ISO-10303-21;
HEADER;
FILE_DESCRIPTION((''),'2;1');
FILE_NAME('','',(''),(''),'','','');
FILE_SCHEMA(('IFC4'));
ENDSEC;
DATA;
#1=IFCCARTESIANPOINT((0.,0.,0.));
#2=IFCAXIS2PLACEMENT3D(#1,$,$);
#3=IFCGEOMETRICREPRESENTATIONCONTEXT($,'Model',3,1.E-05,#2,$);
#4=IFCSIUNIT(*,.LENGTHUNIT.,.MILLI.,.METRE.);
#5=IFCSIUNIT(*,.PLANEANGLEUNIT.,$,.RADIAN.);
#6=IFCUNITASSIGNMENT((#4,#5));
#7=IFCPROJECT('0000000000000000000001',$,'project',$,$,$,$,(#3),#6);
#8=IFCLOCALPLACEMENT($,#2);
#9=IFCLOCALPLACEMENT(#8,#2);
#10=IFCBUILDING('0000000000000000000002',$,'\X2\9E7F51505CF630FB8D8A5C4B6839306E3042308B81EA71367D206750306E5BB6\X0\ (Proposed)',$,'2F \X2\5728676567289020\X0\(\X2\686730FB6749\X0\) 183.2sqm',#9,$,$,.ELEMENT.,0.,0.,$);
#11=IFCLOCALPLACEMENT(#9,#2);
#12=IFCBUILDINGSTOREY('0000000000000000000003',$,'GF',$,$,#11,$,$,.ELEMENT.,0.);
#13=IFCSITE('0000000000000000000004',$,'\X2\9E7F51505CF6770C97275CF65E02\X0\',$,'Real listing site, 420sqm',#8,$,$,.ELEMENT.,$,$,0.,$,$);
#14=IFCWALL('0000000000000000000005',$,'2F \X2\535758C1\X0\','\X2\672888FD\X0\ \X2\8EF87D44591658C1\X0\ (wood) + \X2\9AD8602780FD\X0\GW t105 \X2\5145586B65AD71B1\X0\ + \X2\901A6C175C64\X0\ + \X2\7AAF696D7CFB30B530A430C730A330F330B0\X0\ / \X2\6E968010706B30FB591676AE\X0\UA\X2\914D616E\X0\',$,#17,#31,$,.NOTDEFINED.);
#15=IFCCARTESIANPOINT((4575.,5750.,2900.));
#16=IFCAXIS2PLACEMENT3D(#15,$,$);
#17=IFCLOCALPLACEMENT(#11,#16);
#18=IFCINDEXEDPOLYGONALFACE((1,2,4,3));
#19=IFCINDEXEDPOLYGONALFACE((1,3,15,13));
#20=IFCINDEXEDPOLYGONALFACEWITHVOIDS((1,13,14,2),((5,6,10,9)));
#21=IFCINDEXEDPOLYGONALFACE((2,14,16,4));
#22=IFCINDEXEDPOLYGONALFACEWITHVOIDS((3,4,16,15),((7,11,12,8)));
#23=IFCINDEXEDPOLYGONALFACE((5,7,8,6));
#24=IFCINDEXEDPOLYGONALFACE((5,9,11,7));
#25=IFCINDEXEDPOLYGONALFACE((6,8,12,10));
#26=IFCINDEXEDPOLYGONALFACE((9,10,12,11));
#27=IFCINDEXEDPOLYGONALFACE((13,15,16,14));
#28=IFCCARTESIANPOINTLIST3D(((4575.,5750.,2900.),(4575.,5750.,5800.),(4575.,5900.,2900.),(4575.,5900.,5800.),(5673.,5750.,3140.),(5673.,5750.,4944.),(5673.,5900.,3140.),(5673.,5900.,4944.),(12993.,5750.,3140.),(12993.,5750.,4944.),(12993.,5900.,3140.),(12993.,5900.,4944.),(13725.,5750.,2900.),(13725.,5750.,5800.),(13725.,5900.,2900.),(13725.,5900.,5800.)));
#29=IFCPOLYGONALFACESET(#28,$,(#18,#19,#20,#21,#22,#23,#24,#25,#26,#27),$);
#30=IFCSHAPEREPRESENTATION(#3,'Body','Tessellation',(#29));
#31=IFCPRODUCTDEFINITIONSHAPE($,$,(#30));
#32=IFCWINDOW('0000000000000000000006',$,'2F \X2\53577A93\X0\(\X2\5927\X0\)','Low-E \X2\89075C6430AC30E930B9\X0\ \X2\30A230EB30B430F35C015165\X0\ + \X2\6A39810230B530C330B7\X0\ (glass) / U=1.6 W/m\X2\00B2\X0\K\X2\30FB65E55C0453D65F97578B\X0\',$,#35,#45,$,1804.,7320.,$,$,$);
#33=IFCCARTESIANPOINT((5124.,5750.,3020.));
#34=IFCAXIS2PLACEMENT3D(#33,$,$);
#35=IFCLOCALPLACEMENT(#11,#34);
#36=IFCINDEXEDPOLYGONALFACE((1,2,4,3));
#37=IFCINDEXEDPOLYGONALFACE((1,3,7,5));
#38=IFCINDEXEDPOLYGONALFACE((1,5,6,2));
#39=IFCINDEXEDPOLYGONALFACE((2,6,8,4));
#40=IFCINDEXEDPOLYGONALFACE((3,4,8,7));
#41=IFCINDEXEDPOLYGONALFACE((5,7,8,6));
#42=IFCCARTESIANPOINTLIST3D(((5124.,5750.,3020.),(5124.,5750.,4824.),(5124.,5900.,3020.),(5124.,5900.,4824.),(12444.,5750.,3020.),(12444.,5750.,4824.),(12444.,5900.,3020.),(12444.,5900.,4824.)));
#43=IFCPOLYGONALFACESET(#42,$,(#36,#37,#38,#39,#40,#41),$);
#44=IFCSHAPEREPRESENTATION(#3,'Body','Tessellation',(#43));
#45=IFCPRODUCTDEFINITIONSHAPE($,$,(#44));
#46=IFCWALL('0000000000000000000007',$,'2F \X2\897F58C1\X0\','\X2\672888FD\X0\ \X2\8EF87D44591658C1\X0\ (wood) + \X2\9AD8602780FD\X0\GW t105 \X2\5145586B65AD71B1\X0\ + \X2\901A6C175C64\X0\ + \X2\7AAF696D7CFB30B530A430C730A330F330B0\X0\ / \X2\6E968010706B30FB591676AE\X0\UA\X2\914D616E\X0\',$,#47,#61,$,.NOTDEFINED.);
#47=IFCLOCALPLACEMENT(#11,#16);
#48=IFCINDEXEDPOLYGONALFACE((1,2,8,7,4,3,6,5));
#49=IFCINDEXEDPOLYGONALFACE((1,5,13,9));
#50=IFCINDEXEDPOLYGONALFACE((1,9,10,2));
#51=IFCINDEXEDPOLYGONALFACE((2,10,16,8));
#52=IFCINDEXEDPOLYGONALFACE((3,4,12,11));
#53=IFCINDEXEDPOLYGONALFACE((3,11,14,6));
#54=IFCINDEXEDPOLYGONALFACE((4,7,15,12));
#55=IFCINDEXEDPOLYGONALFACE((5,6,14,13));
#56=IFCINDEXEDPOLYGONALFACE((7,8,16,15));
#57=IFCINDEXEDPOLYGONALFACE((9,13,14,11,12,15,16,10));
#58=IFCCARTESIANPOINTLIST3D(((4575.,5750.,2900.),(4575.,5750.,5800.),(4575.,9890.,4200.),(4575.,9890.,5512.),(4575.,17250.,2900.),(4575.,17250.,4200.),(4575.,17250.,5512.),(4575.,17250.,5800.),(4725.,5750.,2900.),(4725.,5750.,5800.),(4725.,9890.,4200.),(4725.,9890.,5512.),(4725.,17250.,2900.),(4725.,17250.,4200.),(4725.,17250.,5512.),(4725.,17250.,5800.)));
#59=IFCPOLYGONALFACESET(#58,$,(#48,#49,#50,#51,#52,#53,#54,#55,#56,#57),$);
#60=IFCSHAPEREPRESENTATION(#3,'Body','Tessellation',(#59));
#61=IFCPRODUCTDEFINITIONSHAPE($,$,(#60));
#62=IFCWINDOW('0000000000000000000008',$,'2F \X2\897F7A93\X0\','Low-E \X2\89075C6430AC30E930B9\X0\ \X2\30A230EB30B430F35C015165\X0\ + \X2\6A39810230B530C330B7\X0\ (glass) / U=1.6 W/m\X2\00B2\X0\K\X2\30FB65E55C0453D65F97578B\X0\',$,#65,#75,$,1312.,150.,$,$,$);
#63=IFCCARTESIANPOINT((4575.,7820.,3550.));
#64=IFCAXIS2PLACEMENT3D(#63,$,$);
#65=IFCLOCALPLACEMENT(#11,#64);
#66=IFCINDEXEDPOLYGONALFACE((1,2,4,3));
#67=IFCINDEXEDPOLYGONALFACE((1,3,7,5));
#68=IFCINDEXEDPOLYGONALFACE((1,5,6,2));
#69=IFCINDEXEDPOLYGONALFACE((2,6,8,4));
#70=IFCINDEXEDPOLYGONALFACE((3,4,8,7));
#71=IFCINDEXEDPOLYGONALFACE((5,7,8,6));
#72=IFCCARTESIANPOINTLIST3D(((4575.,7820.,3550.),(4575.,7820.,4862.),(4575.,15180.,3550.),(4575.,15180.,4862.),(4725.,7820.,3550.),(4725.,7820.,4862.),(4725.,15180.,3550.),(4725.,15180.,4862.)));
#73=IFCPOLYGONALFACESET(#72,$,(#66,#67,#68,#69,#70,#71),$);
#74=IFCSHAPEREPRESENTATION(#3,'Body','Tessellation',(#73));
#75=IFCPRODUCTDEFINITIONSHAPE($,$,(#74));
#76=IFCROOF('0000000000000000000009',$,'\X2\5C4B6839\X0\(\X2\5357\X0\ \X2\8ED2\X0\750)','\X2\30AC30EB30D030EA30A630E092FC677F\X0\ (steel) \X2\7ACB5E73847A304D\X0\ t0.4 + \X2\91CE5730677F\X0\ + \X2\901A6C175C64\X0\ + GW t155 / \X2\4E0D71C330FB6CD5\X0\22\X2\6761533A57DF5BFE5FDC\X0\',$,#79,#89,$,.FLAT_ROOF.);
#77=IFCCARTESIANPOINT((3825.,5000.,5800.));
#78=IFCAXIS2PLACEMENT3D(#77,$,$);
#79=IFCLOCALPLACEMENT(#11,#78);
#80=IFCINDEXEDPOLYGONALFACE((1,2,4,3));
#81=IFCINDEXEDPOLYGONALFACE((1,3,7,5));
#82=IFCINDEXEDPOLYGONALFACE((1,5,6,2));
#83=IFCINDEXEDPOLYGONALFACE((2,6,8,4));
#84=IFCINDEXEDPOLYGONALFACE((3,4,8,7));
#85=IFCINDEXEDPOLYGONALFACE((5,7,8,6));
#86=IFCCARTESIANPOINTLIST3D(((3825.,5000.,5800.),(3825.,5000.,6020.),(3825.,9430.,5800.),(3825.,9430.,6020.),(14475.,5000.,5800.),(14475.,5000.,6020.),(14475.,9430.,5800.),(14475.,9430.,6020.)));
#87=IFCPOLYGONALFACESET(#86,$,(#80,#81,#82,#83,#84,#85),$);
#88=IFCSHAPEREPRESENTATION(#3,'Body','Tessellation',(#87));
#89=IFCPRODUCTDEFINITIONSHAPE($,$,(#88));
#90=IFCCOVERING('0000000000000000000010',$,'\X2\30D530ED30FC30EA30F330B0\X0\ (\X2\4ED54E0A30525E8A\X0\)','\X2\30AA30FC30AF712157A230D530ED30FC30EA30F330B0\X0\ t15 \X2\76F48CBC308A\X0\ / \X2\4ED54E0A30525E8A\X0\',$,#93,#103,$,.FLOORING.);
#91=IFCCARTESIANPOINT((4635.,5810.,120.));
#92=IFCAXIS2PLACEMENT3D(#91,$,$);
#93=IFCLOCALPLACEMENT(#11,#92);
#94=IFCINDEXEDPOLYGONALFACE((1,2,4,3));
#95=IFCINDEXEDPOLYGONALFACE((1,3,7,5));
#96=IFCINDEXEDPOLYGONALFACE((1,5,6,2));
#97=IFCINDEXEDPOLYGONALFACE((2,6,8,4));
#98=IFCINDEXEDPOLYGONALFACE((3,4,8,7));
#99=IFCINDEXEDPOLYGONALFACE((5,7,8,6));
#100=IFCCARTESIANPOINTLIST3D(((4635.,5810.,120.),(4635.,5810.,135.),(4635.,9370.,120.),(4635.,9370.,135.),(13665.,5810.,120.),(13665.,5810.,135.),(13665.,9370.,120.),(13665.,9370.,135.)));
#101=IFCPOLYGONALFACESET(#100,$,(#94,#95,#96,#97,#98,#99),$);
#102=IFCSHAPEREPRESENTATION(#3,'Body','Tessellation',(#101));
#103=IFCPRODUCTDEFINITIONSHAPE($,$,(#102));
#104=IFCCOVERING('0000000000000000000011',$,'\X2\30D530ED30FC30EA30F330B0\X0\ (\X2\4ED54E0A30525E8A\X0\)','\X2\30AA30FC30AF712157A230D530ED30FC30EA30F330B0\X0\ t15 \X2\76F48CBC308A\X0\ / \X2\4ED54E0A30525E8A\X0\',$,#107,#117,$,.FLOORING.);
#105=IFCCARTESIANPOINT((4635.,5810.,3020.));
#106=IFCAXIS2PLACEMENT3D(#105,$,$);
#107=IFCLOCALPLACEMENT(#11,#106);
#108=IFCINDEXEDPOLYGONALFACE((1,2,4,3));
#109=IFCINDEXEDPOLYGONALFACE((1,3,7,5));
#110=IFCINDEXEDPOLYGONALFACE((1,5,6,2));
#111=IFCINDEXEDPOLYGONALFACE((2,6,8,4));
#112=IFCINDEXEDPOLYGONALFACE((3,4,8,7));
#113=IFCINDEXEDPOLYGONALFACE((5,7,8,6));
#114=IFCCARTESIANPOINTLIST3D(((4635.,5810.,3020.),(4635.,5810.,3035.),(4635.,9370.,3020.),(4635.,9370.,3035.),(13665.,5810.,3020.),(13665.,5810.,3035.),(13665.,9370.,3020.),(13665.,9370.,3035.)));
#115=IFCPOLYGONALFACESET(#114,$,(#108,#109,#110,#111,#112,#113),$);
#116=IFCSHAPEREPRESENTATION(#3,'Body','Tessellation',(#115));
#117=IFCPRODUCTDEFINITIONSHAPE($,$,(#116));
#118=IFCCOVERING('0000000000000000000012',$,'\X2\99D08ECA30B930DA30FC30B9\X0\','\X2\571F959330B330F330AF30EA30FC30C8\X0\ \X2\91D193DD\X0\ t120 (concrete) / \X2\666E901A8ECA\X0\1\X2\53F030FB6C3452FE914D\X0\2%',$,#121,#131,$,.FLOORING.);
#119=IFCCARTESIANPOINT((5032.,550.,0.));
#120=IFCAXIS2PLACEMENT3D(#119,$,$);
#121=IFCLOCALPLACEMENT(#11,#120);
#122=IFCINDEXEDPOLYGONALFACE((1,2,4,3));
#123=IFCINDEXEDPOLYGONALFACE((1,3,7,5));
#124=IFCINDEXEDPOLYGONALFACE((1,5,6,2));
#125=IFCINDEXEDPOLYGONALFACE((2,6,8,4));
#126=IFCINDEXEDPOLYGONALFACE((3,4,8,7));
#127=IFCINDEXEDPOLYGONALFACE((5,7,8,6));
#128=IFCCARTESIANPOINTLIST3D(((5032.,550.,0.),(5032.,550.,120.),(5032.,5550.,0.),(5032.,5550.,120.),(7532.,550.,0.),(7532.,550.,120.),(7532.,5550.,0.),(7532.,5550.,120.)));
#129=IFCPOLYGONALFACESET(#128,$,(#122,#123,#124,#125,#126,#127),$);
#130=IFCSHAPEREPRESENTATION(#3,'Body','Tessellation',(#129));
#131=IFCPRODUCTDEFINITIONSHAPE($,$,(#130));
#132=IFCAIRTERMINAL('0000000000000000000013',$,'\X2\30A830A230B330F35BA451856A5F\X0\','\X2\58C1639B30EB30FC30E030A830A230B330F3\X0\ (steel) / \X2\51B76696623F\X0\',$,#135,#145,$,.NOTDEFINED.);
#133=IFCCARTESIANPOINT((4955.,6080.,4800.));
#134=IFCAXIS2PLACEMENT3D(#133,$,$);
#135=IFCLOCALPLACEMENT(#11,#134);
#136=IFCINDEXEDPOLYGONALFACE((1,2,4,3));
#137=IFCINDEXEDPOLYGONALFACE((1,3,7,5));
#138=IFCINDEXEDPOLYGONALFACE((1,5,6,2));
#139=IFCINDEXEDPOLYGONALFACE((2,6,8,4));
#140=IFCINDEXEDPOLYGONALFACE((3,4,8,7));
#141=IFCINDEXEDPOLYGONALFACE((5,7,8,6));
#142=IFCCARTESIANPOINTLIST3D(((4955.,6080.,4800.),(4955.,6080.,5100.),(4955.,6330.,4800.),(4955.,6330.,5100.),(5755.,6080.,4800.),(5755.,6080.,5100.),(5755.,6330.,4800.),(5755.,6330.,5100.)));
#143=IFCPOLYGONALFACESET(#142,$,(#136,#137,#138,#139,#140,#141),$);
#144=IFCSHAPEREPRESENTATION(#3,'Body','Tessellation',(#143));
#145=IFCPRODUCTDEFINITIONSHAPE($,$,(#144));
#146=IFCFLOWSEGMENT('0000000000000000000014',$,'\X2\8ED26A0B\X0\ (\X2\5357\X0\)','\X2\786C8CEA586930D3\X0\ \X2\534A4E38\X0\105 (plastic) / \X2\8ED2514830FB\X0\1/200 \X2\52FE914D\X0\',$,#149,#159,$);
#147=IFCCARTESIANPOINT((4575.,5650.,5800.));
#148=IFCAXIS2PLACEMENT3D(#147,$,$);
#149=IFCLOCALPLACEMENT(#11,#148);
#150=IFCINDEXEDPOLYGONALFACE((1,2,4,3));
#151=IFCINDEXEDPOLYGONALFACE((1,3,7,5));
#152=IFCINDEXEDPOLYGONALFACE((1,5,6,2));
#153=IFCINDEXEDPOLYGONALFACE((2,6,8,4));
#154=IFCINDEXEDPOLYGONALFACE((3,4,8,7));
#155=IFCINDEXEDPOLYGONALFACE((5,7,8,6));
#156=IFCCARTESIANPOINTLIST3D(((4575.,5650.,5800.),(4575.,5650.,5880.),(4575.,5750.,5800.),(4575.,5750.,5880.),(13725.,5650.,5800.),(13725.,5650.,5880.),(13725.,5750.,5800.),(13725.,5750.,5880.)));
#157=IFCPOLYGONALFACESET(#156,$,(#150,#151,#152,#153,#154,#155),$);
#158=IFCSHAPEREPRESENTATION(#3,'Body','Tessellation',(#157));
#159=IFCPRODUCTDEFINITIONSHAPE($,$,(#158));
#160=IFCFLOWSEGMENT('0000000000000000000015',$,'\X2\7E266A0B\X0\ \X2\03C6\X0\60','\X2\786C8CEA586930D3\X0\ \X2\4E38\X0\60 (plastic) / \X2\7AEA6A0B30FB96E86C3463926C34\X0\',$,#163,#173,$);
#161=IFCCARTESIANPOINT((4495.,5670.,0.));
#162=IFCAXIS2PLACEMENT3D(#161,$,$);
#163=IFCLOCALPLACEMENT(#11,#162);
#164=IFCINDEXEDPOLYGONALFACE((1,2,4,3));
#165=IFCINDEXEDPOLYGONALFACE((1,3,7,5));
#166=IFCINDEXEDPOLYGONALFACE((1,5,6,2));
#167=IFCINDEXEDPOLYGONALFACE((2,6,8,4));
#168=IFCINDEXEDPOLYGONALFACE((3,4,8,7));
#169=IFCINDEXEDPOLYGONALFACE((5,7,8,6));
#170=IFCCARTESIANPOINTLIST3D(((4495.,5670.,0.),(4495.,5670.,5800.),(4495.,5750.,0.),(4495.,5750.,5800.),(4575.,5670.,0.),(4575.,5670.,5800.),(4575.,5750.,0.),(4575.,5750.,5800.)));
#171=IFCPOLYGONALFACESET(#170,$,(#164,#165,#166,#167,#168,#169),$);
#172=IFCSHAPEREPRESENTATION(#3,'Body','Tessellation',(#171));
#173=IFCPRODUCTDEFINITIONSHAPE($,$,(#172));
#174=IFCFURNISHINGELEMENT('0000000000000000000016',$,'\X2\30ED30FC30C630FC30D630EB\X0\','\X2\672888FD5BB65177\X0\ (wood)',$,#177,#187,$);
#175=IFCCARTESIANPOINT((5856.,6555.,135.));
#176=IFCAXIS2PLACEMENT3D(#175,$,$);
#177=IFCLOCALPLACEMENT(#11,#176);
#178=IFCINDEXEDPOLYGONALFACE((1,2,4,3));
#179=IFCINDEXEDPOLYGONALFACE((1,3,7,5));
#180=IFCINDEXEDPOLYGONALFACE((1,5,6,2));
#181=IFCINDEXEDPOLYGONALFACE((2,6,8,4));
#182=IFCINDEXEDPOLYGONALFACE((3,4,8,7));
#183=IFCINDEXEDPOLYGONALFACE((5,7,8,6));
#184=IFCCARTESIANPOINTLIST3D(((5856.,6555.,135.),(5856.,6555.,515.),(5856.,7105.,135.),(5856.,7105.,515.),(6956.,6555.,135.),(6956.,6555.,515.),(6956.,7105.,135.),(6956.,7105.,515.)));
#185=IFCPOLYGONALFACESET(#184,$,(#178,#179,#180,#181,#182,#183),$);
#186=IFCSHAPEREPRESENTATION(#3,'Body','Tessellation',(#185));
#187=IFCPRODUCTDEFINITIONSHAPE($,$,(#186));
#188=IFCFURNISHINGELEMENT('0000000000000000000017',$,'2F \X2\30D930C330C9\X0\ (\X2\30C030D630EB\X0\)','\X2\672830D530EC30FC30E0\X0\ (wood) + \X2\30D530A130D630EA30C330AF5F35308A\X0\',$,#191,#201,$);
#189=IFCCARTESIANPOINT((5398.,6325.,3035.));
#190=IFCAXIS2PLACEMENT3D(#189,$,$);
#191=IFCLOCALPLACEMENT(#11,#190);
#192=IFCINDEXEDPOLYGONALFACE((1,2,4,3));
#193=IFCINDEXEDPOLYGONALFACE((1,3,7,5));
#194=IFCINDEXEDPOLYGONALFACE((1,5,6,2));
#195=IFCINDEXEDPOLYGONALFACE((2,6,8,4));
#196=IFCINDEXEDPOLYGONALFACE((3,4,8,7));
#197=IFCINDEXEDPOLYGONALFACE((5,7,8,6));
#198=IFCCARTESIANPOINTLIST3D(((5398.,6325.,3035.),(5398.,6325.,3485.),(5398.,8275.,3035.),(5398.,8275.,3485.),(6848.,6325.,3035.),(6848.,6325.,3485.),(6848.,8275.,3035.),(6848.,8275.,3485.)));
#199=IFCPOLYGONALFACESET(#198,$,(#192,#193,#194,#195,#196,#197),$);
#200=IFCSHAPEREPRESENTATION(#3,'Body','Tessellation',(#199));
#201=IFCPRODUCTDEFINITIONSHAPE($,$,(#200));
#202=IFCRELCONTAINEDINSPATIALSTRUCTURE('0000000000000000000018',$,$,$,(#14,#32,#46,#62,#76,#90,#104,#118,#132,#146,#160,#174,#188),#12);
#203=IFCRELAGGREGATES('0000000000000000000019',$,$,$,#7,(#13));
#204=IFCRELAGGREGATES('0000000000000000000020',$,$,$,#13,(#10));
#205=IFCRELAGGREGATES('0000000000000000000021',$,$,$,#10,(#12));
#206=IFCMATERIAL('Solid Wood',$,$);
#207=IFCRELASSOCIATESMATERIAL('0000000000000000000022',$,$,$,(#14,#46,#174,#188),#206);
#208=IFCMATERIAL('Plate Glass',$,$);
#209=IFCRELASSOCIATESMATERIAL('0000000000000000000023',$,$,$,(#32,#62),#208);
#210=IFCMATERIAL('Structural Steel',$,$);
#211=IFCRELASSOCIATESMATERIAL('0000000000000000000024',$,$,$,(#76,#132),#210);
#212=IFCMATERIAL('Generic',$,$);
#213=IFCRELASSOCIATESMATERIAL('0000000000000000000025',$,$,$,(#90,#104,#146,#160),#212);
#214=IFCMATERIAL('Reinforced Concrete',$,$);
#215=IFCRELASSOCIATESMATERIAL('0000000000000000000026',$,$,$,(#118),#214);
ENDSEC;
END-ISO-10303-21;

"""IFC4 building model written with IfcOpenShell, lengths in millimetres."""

from ifc_helpers import new_model, si_unit, frame, frame_2d, origin, place, context, project, spatial, rectangle, extrude, material, element, fill, save


model = new_model("IFC4")

# Units and contexts
model_context = context("Model", 3, precision=1e-05, world=origin())
ifc_project = project(units=[si_unit("LENGTHUNIT", "METRE", prefix="MILLI"), si_unit("PLANEANGLEUNIT", "RADIAN")], contexts=[model_context])

# Site, building, storey
site_placement = place(None, origin())
site = spatial("IfcSite", under=ifc_project, at=site_placement, Name="鹿児島県霧島市", ObjectType="Real listing site, 420sqm", CompositionType="ELEMENT", RefElevation=0.0)
building_placement = place(site_placement, origin())
building = spatial("IfcBuilding", under=site, at=building_placement, Name="鹿児島・越屋根のある自然素材の家 (Proposed)", ObjectType="2F 在来木造(桧・杉) 183.2sqm", CompositionType="ELEMENT", ElevationOfRefHeight=0.0, ElevationOfTerrain=0.0)
storey_placement = place(building_placement, origin())
storey = spatial("IfcBuildingStorey", under=building, at=storey_placement, Name="GF", CompositionType="ELEMENT", Elevation=0.0)

# Shared definitions
ifc_material_1 = material(Name="Solid Wood")

# Shared definitions
ifc_material_2 = material(Name="Reinforced Concrete")

# Shared definitions
ifc_material_3 = material(Name="Plate Glass")

# Walls, openings, windows
wall_1_placement = place(storey_placement, frame((4575.0, 5750.0, 2900.0)))
wall_1 = element("IfcWall", 1, at=wall_1_placement, inside=storey, material=ifc_material_1, Name="2F 南壁", Description="木製 軸組外壁 (wood) + 高性能GW t105 充填断熱 + 通気層 + 窯業系サイディング / 準耐火・外皮UA配慮", PredefinedType="NOTDEFINED", context=model_context, shape_type="SweptSolid", body=[
    extrude(rectangle(XDim=9150.0, YDim=150.0, at=frame_2d((4575.0, 75.0))), frame((4575.0, 5750.0, 2900.0)), (0.0, 0.0, 1.0), 2900.0),
])
opening_1_placement = place(storey_placement, frame((5124.0, 5750.0, 3020.0)))
opening_1 = element("IfcOpeningElement", 2, at=opening_1_placement, cuts=wall_1, PredefinedType="NOTDEFINED", context=model_context, shape_type="SweptSolid", body=[
    extrude(rectangle(XDim=7320.0, YDim=150.0, at=frame_2d((3660.0, 75.0))), frame((5124.0, 5750.0, 3020.0)), (0.0, 0.0, 1.0), 1804.0),
])
window_1_placement = place(storey_placement, frame((5124.0, 5750.0, 3020.0)))
window_1 = element("IfcWindow", 3, at=window_1_placement, inside=storey, material=ifc_material_3, Name="2F 南窓(大)", Description="Low-E 複層ガラス アルゴン封入 + 樹脂サッシ (glass) / U=1.6 W/m²K・日射取得型", OverallHeight=1804.0, OverallWidth=7320.0, context=model_context, shape_type="SweptSolid", body=[
    extrude(rectangle(XDim=7320.0, YDim=150.0, at=frame_2d((3660.0, 75.0))), frame((5124.0, 5750.0, 3020.0)), (0.0, 0.0, 1.0), 1804.0),
])
fill(opening_1, window_1)
wall_2_placement = place(storey_placement, frame((4575.0, 5750.0, 2900.0)))
wall_2 = element("IfcWall", 4, at=wall_2_placement, inside=storey, material=ifc_material_1, Name="2F 西壁", Description="木製 軸組外壁 (wood) + 高性能GW t105 充填断熱 + 通気層 + 窯業系サイディング / 準耐火・外皮UA配慮", PredefinedType="NOTDEFINED", context=model_context, shape_type="SweptSolid", body=[
    extrude(rectangle(XDim=150.0, YDim=11500.0, at=frame_2d((75.0, 5750.0))), frame((4575.0, 5750.0, 2900.0)), (0.0, 0.0, 1.0), 2900.0),
])
opening_2_placement = place(storey_placement, frame((4575.0, 7820.0, 3550.0)))
opening_2 = element("IfcOpeningElement", 5, at=opening_2_placement, cuts=wall_2, PredefinedType="NOTDEFINED", context=model_context, shape_type="SweptSolid", body=[
    extrude(rectangle(XDim=150.0, YDim=7360.0, at=frame_2d((75.0, 3680.0))), frame((4575.0, 7820.0, 3550.0)), (0.0, 0.0, 1.0), 1312.0),
])
window_2_placement = place(storey_placement, frame((4575.0, 7820.0, 3550.0)))
window_2 = element("IfcWindow", 6, at=window_2_placement, inside=storey, material=ifc_material_3, Name="2F 西窓", Description="Low-E 複層ガラス アルゴン封入 + 樹脂サッシ (glass) / U=1.6 W/m²K・日射取得型", OverallHeight=1312.0, OverallWidth=150.0, context=model_context, shape_type="SweptSolid", body=[
    extrude(rectangle(XDim=150.0, YDim=7360.0, at=frame_2d((75.0, 3680.0))), frame((4575.0, 7820.0, 3550.0)), (0.0, 0.0, 1.0), 1312.0),
])
fill(opening_2, window_2)

# Roof
ifc_material_4 = material(Name="Structural Steel")
for number, where, name in (
    (7, (3825.0, 5000.0, 5800.0), "屋根(南 軒750)"),
):
    element("IfcRoof", number, at=place(storey_placement, frame(where)), inside=storey, material=ifc_material_4, Name=name, Description="ガルバリウム鋼板 (steel) 立平葺き t0.4 + 野地板 + 通気層 + GW t155 / 不燃・法22条区域対応", PredefinedType="FLAT_ROOF", context=model_context, shape_type="SweptSolid", body=[
        extrude(rectangle(XDim=10650.0, YDim=4430.0, at=frame_2d((5325.0, 2215.0))), frame((3825.0, 5000.0, 5800.0)), (0.0, 0.0, 1.0), 220.0),
    ])

# Coverings
ifc_material_5 = material(Name="Generic")
covering_1_placement = place(storey_placement, frame((4635.0, 5810.0, 120.0)))
element("IfcCovering", 8, at=covering_1_placement, inside=storey, material=ifc_material_5, Name="フローリング (仕上げ床)", Description="オーク無垢フローリング t15 直貼り / 仕上げ床", PredefinedType="FLOORING", context=model_context, shape_type="SweptSolid", body=[
    extrude(rectangle(XDim=9030.0, YDim=3560.0, at=frame_2d((4515.0, 1780.0))), frame((4635.0, 5810.0, 120.0)), (0.0, 0.0, 1.0), 15.0),
])
covering_2_placement = place(storey_placement, frame((4635.0, 5810.0, 3020.0)))
element("IfcCovering", 9, at=covering_2_placement, inside=storey, material=ifc_material_5, Name="フローリング (仕上げ床)", Description="オーク無垢フローリング t15 直貼り / 仕上げ床", PredefinedType="FLOORING", context=model_context, shape_type="SweptSolid", body=[
    extrude(rectangle(XDim=9030.0, YDim=3560.0, at=frame_2d((4515.0, 1780.0))), frame((4635.0, 5810.0, 3020.0)), (0.0, 0.0, 1.0), 15.0),
])
covering_3_placement = place(storey_placement, frame((5032.0, 550.0, 0.0)))
element("IfcCovering", 10, at=covering_3_placement, inside=storey, material=ifc_material_2, Name="駐車スペース", Description="土間コンクリート 金鏝 t120 (concrete) / 普通車1台・水勾配2%", PredefinedType="FLOORING", context=model_context, shape_type="SweptSolid", body=[
    extrude(rectangle(XDim=2500.0, YDim=5000.0, at=frame_2d((1250.0, 2500.0))), frame((5032.0, 550.0, 0.0)), (0.0, 0.0, 1.0), 120.0),
])

# Air terminal
air_terminal_placement = place(storey_placement, frame((4955.0, 6080.0, 4800.0)))
element("IfcAirTerminal", 11, at=air_terminal_placement, inside=storey, material=ifc_material_4, Name="エアコン室内機", Description="壁掛ルームエアコン (steel) / 冷暖房", PredefinedType="NOTDEFINED", context=model_context, shape_type="SweptSolid", body=[
    extrude(rectangle(XDim=800.0, YDim=250.0, at=frame_2d((400.0, 125.0))), frame((4955.0, 6080.0, 4800.0)), (0.0, 0.0, 1.0), 300.0),
])

# Flow segments
flow_segment_1_placement = place(storey_placement, frame((4575.0, 5650.0, 5800.0)))
element("IfcFlowSegment", 12, at=flow_segment_1_placement, inside=storey, material=ifc_material_5, Name="軒樋 (南)", Description="硬質塩ビ 半丸105 (plastic) / 軒先・1/200 勾配", context=model_context, shape_type="SweptSolid", body=[
    extrude(rectangle(XDim=9150.0, YDim=100.0, at=frame_2d((4575.0, 50.0))), frame((4575.0, 5650.0, 5800.0)), (0.0, 0.0, 1.0), 80.0),
])
flow_segment_2_placement = place(storey_placement, frame((4495.0, 5670.0, 0.0)))
element("IfcFlowSegment", 13, at=flow_segment_2_placement, inside=storey, material=ifc_material_5, Name="縦樋 φ60", Description="硬質塩ビ 丸60 (plastic) / 竪樋・雨水排水", context=model_context, shape_type="SweptSolid", body=[
    extrude(rectangle(XDim=80.0, YDim=80.0, at=frame_2d((40.0, 40.0))), frame((4495.0, 5670.0, 0.0)), (0.0, 0.0, 1.0), 5800.0),
])

# Furnishing elements
furnishing_1_placement = place(storey_placement, frame((5856.0, 6555.0, 135.0)))
element("IfcFurnishingElement", 14, at=furnishing_1_placement, inside=storey, material=ifc_material_1, Name="ローテーブル", Description="木製家具 (wood)", context=model_context, shape_type="SweptSolid", body=[
    extrude(rectangle(XDim=1100.0, YDim=550.0, at=frame_2d((550.0, 275.0))), frame((5856.0, 6555.0, 135.0)), (0.0, 0.0, 1.0), 380.0),
])
furnishing_2_placement = place(storey_placement, frame((5398.0, 6325.0, 3035.0)))
element("IfcFurnishingElement", 15, at=furnishing_2_placement, inside=storey, material=ifc_material_1, Name="2F ベッド (ダブル)", Description="木フレーム (wood) + ファブリック張り", context=model_context, shape_type="SweptSolid", body=[
    extrude(rectangle(XDim=1450.0, YDim=1950.0, at=frame_2d((725.0, 975.0))), frame((5398.0, 6325.0, 3035.0)), (0.0, 0.0, 1.0), 450.0),
])

save(model, "model.ifc")
